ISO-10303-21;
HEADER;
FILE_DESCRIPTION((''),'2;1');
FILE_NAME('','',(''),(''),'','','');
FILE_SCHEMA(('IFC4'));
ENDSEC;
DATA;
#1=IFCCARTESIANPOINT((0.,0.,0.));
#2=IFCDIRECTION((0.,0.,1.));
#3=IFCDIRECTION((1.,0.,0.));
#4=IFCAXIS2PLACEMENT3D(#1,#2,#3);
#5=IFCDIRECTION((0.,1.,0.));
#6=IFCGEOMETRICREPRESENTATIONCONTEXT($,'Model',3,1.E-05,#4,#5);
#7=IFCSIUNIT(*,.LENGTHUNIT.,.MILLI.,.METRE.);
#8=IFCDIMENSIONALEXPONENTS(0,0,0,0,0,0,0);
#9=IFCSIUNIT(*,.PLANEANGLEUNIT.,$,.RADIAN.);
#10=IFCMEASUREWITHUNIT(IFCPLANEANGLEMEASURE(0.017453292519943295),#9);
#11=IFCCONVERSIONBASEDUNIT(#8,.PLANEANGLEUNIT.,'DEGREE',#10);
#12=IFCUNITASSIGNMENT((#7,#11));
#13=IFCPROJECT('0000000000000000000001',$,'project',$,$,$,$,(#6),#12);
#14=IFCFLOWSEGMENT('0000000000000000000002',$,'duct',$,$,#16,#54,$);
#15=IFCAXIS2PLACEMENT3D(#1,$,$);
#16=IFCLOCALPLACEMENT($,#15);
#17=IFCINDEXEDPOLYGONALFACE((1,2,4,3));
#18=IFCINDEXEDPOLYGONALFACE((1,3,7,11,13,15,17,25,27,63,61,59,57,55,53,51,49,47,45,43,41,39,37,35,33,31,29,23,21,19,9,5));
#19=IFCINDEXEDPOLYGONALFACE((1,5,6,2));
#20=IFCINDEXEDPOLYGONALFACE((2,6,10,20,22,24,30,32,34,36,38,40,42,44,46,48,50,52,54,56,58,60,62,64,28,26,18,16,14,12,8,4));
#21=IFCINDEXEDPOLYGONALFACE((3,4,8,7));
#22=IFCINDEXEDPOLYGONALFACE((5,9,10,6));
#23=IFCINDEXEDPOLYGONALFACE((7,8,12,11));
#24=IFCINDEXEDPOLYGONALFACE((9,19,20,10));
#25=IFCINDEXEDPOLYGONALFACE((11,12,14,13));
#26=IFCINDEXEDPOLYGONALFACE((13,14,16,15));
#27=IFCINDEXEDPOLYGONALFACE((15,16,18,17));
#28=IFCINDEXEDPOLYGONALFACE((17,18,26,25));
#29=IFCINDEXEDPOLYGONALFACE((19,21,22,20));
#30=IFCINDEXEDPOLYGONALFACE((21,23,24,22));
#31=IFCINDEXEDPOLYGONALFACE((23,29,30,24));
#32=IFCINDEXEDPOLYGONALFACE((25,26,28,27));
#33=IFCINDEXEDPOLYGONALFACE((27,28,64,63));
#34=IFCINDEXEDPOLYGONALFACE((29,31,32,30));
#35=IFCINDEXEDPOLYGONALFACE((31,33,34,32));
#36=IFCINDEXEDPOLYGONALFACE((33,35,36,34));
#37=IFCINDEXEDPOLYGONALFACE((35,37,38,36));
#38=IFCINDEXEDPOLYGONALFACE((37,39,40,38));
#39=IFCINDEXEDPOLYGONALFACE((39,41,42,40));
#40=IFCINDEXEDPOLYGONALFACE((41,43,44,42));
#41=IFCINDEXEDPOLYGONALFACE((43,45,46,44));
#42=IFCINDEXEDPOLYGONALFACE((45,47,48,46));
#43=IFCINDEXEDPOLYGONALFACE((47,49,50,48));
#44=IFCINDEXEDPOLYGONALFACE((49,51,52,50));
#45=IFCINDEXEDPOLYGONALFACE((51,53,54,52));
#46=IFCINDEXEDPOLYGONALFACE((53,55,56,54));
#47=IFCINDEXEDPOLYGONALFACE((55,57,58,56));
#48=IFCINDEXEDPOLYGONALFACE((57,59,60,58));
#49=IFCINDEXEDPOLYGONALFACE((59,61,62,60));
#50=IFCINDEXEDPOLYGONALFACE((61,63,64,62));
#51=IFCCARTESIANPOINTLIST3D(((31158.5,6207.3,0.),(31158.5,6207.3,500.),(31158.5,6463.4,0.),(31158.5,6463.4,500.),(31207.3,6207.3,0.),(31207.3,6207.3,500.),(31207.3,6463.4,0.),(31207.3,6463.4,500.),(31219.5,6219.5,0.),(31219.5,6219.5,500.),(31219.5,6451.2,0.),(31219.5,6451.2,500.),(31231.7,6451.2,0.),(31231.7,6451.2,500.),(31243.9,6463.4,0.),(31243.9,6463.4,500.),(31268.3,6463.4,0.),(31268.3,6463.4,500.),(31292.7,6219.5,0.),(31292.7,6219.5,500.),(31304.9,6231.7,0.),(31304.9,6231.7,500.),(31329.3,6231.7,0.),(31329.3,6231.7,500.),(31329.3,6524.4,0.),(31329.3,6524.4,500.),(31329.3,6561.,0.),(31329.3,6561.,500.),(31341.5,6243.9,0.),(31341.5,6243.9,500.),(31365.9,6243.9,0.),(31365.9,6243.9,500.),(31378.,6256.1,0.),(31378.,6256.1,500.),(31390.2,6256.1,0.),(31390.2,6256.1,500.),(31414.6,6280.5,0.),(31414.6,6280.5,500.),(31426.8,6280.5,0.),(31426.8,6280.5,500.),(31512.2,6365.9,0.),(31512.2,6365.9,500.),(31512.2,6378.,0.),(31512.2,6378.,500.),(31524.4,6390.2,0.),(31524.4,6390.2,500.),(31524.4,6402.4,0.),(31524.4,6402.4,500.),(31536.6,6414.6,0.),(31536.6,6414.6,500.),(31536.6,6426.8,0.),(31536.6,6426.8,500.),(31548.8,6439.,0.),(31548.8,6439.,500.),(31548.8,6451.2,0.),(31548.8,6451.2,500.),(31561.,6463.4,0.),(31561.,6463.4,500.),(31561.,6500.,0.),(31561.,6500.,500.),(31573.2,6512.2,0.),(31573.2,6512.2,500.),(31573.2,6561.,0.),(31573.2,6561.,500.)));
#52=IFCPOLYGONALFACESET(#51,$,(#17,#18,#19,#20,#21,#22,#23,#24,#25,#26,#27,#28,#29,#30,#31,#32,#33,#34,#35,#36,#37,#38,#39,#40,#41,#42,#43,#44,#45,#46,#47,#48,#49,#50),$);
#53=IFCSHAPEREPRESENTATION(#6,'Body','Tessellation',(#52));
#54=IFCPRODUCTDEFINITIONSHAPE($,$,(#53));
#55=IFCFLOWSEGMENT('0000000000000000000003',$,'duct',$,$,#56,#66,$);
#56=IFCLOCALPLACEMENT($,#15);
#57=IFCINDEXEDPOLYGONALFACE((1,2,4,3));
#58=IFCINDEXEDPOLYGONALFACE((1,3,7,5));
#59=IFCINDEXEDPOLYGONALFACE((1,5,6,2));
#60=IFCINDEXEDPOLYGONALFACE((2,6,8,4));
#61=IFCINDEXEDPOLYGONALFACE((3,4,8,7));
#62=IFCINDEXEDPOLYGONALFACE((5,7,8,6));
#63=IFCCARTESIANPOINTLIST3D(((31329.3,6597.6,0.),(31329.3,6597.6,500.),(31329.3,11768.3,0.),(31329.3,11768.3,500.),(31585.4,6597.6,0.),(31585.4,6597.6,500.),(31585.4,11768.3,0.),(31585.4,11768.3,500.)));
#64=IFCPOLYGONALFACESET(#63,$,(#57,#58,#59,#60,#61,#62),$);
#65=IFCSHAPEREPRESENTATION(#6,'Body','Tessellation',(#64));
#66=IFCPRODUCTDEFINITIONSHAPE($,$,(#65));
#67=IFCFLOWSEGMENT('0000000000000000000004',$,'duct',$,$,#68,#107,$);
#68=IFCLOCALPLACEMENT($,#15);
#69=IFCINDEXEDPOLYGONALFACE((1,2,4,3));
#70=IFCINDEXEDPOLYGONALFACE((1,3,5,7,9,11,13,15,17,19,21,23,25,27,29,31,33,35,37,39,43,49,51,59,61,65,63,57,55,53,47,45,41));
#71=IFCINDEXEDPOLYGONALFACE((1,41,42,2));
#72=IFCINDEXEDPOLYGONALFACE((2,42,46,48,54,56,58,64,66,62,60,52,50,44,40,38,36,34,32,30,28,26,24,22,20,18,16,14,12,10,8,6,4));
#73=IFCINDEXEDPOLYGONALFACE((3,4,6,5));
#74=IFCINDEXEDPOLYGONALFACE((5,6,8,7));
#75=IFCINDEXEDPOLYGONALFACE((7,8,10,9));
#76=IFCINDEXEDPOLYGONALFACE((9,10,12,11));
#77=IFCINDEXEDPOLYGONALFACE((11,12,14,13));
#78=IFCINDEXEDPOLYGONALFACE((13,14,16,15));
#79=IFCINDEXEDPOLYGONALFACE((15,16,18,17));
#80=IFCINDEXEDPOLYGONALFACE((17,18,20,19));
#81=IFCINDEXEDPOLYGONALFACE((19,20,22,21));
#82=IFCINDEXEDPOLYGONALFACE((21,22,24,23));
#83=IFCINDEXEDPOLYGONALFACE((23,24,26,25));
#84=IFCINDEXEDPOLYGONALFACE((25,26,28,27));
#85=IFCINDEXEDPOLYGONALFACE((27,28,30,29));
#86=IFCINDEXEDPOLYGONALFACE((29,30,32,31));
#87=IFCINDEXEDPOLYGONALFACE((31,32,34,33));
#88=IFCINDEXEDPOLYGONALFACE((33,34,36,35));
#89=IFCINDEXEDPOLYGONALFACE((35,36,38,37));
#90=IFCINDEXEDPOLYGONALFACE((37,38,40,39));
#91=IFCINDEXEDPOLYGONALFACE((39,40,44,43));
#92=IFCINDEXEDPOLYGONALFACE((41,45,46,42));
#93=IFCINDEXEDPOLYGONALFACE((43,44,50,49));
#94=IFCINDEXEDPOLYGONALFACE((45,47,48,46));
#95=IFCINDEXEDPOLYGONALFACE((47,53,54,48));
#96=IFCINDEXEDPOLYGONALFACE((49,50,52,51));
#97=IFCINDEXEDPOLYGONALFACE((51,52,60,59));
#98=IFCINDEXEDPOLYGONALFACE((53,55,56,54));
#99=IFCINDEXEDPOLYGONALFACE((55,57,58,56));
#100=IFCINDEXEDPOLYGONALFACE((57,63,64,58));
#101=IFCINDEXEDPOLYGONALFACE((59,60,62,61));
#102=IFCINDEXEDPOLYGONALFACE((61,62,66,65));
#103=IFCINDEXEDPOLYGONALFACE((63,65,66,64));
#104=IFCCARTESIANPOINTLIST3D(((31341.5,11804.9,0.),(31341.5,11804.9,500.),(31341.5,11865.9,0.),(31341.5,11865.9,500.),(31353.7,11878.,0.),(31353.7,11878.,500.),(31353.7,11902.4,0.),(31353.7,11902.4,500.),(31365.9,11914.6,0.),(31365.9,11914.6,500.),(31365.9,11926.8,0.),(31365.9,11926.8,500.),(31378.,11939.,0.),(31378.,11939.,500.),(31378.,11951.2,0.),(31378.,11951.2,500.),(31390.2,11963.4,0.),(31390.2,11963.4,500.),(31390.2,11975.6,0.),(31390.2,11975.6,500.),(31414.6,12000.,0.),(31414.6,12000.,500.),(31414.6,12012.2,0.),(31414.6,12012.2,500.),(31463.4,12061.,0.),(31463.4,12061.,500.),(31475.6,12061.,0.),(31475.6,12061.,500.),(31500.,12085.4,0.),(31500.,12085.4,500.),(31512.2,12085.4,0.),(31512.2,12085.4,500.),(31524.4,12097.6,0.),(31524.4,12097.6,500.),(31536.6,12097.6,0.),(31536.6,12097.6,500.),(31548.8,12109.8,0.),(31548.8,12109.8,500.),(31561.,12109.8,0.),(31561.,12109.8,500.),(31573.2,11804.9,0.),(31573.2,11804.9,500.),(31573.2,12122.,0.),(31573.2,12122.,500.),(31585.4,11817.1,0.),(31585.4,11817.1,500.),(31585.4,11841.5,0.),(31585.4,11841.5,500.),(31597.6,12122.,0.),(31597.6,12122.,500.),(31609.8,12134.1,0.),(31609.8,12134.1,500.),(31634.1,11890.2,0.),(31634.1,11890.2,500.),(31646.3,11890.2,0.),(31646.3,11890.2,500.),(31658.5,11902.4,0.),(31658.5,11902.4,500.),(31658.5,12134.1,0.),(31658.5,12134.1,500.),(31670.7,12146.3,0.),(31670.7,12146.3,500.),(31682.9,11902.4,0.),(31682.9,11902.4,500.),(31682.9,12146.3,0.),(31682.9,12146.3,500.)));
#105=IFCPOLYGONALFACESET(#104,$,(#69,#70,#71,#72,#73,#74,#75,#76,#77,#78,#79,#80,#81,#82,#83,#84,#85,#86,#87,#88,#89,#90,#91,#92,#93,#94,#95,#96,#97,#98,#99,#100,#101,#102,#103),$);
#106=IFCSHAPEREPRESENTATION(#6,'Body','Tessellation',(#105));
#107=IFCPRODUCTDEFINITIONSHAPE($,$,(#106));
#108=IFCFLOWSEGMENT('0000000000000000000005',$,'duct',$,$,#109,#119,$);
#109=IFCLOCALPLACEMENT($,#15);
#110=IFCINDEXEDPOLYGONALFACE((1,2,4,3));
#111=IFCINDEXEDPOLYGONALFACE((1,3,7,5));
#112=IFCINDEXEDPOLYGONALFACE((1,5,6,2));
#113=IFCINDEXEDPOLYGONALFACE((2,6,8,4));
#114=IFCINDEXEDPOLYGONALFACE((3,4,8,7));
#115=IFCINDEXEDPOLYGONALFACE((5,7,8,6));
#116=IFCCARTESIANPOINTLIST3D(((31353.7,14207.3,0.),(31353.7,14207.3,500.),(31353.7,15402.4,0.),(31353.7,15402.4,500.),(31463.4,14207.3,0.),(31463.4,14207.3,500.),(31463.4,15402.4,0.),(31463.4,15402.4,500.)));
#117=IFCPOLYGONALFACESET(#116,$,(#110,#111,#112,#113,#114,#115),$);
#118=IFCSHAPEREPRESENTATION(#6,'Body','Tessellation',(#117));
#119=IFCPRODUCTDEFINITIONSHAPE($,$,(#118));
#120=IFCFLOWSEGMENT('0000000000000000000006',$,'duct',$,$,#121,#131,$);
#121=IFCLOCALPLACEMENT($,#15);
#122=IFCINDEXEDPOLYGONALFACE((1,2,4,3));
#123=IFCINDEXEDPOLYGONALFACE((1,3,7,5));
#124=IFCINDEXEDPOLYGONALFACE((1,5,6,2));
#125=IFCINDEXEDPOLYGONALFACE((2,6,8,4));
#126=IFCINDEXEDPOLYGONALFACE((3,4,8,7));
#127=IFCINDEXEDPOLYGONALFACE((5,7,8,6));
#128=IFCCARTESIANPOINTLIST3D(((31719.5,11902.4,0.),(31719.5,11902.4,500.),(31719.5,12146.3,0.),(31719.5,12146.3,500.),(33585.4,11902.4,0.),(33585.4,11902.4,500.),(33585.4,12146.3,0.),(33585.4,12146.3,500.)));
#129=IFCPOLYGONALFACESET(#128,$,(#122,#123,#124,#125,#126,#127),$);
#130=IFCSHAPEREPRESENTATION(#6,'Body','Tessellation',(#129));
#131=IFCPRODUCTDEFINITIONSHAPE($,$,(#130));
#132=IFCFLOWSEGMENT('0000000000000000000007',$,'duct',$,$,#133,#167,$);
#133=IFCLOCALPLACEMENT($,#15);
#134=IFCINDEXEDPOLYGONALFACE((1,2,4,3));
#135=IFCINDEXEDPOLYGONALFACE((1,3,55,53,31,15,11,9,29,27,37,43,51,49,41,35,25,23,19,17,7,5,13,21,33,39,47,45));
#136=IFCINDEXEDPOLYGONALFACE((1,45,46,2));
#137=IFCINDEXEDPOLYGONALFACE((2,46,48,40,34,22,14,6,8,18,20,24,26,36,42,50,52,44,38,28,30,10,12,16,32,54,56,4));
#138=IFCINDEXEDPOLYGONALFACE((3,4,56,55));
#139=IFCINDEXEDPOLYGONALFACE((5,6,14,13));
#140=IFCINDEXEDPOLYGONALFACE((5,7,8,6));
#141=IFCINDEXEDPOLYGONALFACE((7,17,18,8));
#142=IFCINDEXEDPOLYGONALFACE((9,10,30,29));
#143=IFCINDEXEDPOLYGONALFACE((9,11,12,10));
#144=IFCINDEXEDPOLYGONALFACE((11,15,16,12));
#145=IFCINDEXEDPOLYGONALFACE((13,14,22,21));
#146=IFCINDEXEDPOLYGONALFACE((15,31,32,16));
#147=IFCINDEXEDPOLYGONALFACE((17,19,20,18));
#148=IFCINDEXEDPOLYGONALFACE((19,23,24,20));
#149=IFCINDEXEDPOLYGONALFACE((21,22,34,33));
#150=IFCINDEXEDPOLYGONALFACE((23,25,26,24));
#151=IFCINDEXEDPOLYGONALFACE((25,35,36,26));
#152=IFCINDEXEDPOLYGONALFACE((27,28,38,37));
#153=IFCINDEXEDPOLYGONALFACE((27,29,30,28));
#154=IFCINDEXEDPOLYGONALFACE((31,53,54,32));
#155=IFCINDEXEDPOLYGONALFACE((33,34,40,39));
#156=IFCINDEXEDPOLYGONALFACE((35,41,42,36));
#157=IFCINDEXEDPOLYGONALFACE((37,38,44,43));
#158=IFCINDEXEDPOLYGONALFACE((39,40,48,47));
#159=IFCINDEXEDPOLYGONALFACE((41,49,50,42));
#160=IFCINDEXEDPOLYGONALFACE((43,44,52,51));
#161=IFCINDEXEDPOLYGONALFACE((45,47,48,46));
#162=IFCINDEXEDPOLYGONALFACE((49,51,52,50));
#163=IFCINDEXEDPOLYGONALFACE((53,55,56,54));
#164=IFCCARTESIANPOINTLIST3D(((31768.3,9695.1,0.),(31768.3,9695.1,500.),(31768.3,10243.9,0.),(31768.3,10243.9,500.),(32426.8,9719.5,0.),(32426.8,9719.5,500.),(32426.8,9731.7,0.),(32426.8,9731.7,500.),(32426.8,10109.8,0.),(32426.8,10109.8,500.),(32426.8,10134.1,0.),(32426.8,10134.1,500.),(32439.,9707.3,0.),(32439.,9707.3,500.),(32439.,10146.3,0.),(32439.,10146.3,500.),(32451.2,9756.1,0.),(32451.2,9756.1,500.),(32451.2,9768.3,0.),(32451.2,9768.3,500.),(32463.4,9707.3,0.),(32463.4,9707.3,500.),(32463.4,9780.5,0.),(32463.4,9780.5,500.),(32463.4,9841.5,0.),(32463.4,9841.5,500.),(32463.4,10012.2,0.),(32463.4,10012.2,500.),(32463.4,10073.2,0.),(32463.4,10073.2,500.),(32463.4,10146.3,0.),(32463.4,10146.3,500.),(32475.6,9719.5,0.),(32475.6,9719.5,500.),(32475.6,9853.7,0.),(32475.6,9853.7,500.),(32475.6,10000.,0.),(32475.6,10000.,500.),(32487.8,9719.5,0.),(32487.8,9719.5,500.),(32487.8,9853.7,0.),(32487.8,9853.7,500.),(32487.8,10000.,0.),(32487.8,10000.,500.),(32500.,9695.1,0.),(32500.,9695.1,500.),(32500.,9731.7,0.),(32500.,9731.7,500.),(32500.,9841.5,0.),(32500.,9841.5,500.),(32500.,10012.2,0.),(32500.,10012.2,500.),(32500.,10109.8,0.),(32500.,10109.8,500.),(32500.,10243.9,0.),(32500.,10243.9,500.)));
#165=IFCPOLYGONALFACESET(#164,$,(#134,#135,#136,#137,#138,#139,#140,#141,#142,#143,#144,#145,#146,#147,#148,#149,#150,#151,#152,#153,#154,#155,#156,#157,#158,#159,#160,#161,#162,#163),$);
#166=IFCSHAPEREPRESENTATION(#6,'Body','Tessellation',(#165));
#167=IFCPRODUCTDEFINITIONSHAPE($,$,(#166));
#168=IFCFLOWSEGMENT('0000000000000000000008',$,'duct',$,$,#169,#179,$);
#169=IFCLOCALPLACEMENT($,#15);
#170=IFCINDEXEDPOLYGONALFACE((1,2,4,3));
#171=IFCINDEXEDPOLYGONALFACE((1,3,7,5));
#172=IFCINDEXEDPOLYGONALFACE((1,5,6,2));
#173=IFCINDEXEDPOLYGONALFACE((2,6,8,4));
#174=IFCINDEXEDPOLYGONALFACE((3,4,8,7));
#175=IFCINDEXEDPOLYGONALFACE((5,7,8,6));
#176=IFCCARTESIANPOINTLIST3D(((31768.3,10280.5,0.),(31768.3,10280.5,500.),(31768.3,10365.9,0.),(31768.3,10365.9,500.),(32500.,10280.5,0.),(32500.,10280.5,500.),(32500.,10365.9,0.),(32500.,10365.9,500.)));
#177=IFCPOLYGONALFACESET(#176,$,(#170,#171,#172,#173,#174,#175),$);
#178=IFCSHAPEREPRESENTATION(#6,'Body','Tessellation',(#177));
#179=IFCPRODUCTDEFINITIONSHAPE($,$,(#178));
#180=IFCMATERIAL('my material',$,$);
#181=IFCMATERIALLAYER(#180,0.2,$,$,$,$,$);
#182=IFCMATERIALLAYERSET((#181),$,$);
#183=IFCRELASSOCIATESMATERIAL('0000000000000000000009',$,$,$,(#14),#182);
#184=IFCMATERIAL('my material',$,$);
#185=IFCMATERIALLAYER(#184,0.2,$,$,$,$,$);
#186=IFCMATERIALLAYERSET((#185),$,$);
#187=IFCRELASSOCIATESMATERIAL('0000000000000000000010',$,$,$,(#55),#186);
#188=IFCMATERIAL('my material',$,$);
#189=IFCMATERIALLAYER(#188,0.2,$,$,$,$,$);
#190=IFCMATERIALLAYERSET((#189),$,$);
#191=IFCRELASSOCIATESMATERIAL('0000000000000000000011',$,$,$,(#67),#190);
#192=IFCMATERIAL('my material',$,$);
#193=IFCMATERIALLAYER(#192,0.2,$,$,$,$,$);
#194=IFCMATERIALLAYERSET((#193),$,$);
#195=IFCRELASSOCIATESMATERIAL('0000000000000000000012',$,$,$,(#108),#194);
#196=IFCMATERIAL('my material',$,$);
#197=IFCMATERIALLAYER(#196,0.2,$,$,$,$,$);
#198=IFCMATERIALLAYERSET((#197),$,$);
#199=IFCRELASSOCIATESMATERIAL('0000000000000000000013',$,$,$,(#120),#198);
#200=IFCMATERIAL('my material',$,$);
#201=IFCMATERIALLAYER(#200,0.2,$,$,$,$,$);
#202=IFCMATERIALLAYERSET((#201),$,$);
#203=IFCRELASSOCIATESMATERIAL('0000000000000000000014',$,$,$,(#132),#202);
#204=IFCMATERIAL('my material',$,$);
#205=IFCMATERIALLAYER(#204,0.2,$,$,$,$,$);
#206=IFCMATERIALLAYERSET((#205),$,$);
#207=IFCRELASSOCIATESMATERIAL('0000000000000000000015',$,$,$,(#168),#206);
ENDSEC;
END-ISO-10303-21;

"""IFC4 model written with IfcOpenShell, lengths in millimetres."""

from ifc_helpers import new_model, entity, si_unit, converted_unit, direction, origin_with_axes, place, context, project, polyline, outline, extrude, material, layer, layer_set, layer_usage, element, save


model = new_model("IFC4")

# Units and contexts
model_context = context("Model", 3, precision=1e-05, world=origin_with_axes(), true_north=direction((0.0, 1.0, 0.0)))
ifc_project = project(units=[si_unit("LENGTHUNIT", "METRE", prefix="MILLI"), converted_unit("PLANEANGLEUNIT", "DEGREE", entity("IfcPlaneAngleMeasure", 0.017453292519943295), si_unit("PLANEANGLEUNIT", "RADIAN"), dimensions=[0, 0, 0, 0, 0, 0, 0])], contexts=[model_context])

# Flow segments
ifc_material_1 = material(Name="my material")
ifc_layer_1 = layer(ifc_material_1, 0.2)
ifc_layer_set_1 = layer_set([ifc_layer_1])
ifc_layer_usage_1 = layer_usage(ifc_layer_set_1, "AXIS2", "POSITIVE", -0.1)
flow_segment_1_placement = place(None, origin_with_axes())
element("IfcFlowSegment", 1, at=flow_segment_1_placement, material=ifc_layer_usage_1, Name="duct", context=model_context, shape_type="SweptSolid", body=[
    extrude(outline(polyline([(31158.5, 6207.3), (31207.3, 6207.3), (31219.5, 6219.5), (31292.7, 6219.5), (31304.9, 6231.7), (31329.3, 6231.7), (31341.5, 6243.9), (31365.9, 6243.9), (31378.0, 6256.1), (31390.2, 6256.1), (31414.6, 6280.5), (31426.8, 6280.5), (31512.2, 6365.9), (31512.2, 6378.0), (31524.4, 6390.2), (31524.4, 6402.4), (31536.6, 6414.6), (31536.6, 6426.8), (31548.8, 6439.0), (31548.8, 6451.2), (31561.0, 6463.4), (31561.0, 6500.0), (31573.2, 6512.2), (31573.2, 6561.0), (31329.3, 6561.0), (31329.3, 6524.4), (31268.3, 6463.4), (31243.9, 6463.4), (31231.7, 6451.2), (31219.5, 6451.2), (31207.3, 6463.4), (31158.5, 6463.4), (31158.5, 6207.3)])), origin_with_axes(), (0.0, 0.0, 1.0), 500.0),
])
ifc_material_2 = material(Name="my material")
ifc_layer_2 = layer(ifc_material_2, 0.2)
ifc_layer_set_2 = layer_set([ifc_layer_2])
ifc_layer_usage_2 = layer_usage(ifc_layer_set_2, "AXIS2", "POSITIVE", -0.1)
flow_segment_2_placement = place(None, origin_with_axes())
element("IfcFlowSegment", 2, at=flow_segment_2_placement, material=ifc_layer_usage_2, Name="duct", context=model_context, shape_type="SweptSolid", body=[
    extrude(outline(polyline([(31329.3, 6597.6), (31585.4, 6597.6), (31585.4, 11768.3), (31329.3, 11768.3), (31329.3, 6597.6)])), origin_with_axes(), (0.0, 0.0, 1.0), 500.0),
])
ifc_material_3 = material(Name="my material")
ifc_layer_3 = layer(ifc_material_3, 0.2)
ifc_layer_set_3 = layer_set([ifc_layer_3])
ifc_layer_usage_3 = layer_usage(ifc_layer_set_3, "AXIS2", "POSITIVE", -0.1)
flow_segment_3_placement = place(None, origin_with_axes())
element("IfcFlowSegment", 3, at=flow_segment_3_placement, material=ifc_layer_usage_3, Name="duct", context=model_context, shape_type="SweptSolid", body=[
    extrude(outline(polyline([(31341.5, 11804.9), (31573.2, 11804.9), (31585.4, 11817.1), (31585.4, 11841.5), (31634.1, 11890.2), (31646.3, 11890.2), (31658.5, 11902.4), (31682.9, 11902.4), (31682.9, 12146.3), (31670.7, 12146.3), (31658.5, 12134.1), (31609.8, 12134.1), (31597.6, 12122.0), (31573.2, 12122.0), (31561.0, 12109.8), (31548.8, 12109.8), (31536.6, 12097.6), (31524.4, 12097.6), (31512.2, 12085.4), (31500.0, 12085.4), (31475.6, 12061.0), (31463.4, 12061.0), (31414.6, 12012.2), (31414.6, 12000.0), (31390.2, 11975.6), (31390.2, 11963.4), (31378.0, 11951.2), (31378.0, 11939.0), (31365.9, 11926.8), (31365.9, 11914.6), (31353.7, 11902.4), (31353.7, 11878.0), (31341.5, 11865.9), (31341.5, 11804.9)])), origin_with_axes(), (0.0, 0.0, 1.0), 500.0),
])
ifc_material_4 = material(Name="my material")
ifc_layer_4 = layer(ifc_material_4, 0.2)
ifc_layer_set_4 = layer_set([ifc_layer_4])
ifc_layer_usage_4 = layer_usage(ifc_layer_set_4, "AXIS2", "POSITIVE", -0.1)
flow_segment_4_placement = place(None, origin_with_axes())
element("IfcFlowSegment", 4, at=flow_segment_4_placement, material=ifc_layer_usage_4, Name="duct", context=model_context, shape_type="SweptSolid", body=[
    extrude(outline(polyline([(31353.7, 14207.3), (31463.4, 14207.3), (31463.4, 15402.4), (31353.7, 15402.4), (31353.7, 14207.3)])), origin_with_axes(), (0.0, 0.0, 1.0), 500.0),
])
ifc_material_5 = material(Name="my material")
ifc_layer_5 = layer(ifc_material_5, 0.2)
ifc_layer_set_5 = layer_set([ifc_layer_5])
ifc_layer_usage_5 = layer_usage(ifc_layer_set_5, "AXIS2", "POSITIVE", -0.1)
flow_segment_5_placement = place(None, origin_with_axes())
element("IfcFlowSegment", 5, at=flow_segment_5_placement, material=ifc_layer_usage_5, Name="duct", context=model_context, shape_type="SweptSolid", body=[
    extrude(outline(polyline([(31719.5, 11902.4), (33585.4, 11902.4), (33585.4, 12146.3), (31719.5, 12146.3), (31719.5, 11902.4)])), origin_with_axes(), (0.0, 0.0, 1.0), 500.0),
])
ifc_material_6 = material(Name="my material")
ifc_layer_6 = layer(ifc_material_6, 0.2)
ifc_layer_set_6 = layer_set([ifc_layer_6])
ifc_layer_usage_6 = layer_usage(ifc_layer_set_6, "AXIS2", "POSITIVE", -0.1)
flow_segment_6_placement = place(None, origin_with_axes())
element("IfcFlowSegment", 6, at=flow_segment_6_placement, material=ifc_layer_usage_6, Name="duct", context=model_context, shape_type="SweptSolid", body=[
    extrude(outline(polyline([(31768.3, 9695.1), (32500.0, 9695.1), (32500.0, 9756.1), (32500.0, 9731.7), (32487.8, 9719.5), (32475.6, 9719.5), (32463.4, 9707.3), (32439.0, 9707.3), (32426.8, 9719.5), (32426.8, 9731.7), (32451.2, 9756.1), (32451.2, 9768.3), (32463.4, 9780.5), (32463.4, 9841.5), (32475.6, 9853.7), (32487.8, 9853.7), (32500.0, 9841.5), (32500.0, 9792.7), (32500.0, 10061.0), (32500.0, 10012.2), (32487.8, 10000.0), (32475.6, 10000.0), (32463.4, 10012.2), (32463.4, 10073.2), (32426.8, 10109.8), (32426.8, 10134.1), (32439.0, 10146.3), (32463.4, 10146.3), (32500.0, 10109.8), (32500.0, 10097.6), (32500.0, 10243.9), (31768.3, 10243.9), (31768.3, 9695.1)])), origin_with_axes(), (0.0, 0.0, 1.0), 500.0),
])
ifc_material_7 = material(Name="my material")
ifc_layer_7 = layer(ifc_material_7, 0.2)
ifc_layer_set_7 = layer_set([ifc_layer_7])
ifc_layer_usage_7 = layer_usage(ifc_layer_set_7, "AXIS2", "POSITIVE", -0.1)
flow_segment_7_placement = place(None, origin_with_axes())
element("IfcFlowSegment", 7, at=flow_segment_7_placement, material=ifc_layer_usage_7, Name="duct", context=model_context, shape_type="SweptSolid", body=[
    extrude(outline(polyline([(31768.3, 10280.5), (32500.0, 10280.5), (32500.0, 10365.9), (31768.3, 10365.9), (31768.3, 10280.5)])), origin_with_axes(), (0.0, 0.0, 1.0), 500.0),
])

save(model, "model.ifc")
